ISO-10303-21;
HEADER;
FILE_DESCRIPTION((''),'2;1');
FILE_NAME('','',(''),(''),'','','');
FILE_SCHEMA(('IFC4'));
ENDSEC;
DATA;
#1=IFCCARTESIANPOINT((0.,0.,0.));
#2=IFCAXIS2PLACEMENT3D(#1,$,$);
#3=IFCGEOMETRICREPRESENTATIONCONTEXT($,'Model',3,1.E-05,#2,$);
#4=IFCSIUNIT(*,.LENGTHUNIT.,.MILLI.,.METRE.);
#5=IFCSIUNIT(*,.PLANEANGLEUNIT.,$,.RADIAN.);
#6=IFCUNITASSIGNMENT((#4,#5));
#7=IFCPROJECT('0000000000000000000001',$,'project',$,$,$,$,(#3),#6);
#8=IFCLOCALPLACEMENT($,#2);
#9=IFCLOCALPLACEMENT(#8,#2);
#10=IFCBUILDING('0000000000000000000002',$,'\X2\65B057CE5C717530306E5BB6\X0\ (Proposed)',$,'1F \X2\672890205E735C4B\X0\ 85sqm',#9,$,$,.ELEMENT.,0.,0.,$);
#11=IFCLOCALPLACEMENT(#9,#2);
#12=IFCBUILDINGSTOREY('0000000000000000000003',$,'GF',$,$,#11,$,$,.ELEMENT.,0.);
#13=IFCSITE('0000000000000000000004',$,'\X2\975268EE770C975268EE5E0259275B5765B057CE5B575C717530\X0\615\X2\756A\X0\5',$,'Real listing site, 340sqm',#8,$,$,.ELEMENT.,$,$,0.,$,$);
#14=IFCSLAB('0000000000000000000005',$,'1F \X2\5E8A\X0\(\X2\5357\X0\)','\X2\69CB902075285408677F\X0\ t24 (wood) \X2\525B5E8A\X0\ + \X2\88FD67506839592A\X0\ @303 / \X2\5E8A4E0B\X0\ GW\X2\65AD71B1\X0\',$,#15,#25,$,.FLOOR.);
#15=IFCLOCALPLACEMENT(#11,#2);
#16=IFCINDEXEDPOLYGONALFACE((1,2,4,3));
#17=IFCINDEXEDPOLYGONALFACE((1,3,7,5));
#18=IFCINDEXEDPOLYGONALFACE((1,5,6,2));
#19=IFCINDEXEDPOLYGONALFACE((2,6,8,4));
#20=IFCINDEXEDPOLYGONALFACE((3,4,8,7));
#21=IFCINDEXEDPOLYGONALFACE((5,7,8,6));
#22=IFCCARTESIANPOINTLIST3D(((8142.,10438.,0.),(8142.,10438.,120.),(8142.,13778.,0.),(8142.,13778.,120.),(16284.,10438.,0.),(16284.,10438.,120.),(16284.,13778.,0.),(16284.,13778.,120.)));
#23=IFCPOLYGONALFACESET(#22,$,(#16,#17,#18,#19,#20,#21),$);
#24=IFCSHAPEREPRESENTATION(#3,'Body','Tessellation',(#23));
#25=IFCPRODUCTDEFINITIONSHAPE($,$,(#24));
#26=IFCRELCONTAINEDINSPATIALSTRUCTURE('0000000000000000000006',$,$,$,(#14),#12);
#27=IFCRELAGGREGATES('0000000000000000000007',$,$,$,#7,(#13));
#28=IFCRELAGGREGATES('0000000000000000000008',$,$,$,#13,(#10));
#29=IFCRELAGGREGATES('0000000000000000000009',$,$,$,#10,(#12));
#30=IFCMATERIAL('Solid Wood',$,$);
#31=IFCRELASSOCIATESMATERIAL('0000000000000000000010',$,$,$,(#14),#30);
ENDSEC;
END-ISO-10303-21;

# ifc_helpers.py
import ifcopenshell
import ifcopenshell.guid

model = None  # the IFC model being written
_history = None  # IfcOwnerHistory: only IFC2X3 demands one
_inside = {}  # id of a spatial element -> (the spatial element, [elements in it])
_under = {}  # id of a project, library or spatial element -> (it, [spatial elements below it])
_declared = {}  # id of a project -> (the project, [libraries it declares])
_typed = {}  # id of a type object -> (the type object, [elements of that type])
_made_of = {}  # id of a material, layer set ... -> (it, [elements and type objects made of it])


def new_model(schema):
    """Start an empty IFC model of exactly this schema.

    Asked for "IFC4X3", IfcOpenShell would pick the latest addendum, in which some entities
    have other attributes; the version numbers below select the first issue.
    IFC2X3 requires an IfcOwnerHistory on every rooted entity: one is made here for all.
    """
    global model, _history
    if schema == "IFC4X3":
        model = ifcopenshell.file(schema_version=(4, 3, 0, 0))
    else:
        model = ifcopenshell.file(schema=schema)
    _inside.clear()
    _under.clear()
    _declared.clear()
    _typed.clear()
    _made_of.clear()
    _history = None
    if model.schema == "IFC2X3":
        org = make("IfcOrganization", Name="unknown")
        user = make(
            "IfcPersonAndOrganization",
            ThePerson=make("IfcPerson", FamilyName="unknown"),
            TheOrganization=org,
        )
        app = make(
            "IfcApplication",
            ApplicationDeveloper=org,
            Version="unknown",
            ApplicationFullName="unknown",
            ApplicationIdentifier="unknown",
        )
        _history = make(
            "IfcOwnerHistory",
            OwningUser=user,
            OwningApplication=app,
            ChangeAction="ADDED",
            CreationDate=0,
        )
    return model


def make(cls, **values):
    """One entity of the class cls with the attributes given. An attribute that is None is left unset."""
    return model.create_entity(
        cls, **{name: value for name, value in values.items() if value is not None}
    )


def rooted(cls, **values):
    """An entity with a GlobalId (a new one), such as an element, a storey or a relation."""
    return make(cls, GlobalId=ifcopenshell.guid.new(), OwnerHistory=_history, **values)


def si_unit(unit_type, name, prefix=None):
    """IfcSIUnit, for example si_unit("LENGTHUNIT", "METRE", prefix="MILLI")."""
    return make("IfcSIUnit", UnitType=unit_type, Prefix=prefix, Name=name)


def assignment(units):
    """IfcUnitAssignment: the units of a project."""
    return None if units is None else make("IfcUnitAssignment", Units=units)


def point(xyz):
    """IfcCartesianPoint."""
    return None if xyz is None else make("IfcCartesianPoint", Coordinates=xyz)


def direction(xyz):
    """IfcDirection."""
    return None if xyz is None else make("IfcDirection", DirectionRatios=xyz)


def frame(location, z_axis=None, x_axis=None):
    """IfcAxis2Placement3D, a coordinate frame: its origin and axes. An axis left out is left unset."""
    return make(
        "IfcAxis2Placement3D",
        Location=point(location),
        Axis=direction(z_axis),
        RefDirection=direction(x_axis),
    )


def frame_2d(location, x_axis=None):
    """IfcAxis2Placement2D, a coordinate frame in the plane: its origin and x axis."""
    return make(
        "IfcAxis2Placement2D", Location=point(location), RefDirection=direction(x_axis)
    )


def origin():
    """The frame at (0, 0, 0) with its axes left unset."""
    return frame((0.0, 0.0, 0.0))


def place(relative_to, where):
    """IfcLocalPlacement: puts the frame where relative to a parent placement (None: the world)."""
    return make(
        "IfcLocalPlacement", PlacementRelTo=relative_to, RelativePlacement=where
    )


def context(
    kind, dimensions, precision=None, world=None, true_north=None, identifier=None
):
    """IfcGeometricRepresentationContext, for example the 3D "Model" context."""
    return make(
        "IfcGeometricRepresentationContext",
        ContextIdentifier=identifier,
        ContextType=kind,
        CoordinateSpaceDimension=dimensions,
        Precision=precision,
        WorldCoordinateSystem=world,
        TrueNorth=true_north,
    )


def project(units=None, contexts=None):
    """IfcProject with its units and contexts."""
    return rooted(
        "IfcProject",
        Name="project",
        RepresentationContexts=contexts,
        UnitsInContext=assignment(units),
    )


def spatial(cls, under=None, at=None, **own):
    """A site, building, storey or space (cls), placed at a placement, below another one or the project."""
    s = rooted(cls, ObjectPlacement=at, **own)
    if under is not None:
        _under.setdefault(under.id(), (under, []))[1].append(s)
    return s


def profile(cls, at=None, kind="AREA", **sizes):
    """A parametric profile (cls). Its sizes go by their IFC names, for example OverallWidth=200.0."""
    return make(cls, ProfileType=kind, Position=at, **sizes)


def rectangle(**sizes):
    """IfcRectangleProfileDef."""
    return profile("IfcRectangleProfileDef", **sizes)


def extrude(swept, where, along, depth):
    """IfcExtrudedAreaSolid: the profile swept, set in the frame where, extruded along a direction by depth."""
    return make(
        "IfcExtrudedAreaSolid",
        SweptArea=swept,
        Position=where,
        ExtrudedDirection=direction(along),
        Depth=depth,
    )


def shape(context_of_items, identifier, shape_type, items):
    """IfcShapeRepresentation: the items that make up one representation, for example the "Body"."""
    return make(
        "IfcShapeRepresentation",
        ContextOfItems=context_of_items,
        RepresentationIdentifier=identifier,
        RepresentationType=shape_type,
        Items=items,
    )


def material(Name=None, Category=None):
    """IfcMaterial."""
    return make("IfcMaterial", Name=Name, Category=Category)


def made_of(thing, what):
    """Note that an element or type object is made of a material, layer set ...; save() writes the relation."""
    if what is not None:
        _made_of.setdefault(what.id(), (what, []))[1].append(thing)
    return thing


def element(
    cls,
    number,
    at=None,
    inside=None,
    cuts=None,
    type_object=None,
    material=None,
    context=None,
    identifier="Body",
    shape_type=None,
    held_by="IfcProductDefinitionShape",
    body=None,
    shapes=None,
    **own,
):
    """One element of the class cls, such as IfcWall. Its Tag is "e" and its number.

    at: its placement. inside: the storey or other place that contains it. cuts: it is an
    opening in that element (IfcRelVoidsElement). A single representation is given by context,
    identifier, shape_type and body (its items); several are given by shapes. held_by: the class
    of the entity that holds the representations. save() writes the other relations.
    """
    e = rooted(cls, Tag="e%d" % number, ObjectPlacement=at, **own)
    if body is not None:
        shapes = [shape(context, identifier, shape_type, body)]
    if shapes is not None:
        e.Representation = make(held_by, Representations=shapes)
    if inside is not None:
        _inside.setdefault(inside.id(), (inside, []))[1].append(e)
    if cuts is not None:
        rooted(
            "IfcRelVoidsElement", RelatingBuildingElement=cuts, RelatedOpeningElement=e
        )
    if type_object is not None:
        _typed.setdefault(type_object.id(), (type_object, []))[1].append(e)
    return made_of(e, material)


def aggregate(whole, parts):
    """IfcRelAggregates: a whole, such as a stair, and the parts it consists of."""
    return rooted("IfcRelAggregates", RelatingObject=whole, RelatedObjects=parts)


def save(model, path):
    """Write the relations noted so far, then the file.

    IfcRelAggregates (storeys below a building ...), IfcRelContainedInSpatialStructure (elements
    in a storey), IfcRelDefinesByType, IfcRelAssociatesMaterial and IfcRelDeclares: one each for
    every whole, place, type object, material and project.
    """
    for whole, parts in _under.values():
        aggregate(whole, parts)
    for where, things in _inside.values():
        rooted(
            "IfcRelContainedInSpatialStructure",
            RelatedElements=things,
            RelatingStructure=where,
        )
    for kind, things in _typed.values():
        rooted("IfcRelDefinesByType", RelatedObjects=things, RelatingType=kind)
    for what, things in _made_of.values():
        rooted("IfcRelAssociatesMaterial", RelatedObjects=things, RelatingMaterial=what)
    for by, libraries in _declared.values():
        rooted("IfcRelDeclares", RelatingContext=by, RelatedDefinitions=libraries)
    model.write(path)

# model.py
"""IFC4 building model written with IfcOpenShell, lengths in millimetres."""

from ifc_helpers import new_model, si_unit, frame, frame_2d, origin, place, context, project, spatial, rectangle, extrude, material, element, save


model = new_model("IFC4")

# Units and contexts
model_context = context("Model", 3, precision=1e-05, world=origin())
ifc_project = project(units=[si_unit("LENGTHUNIT", "METRE", prefix="MILLI"), si_unit("PLANEANGLEUNIT", "RADIAN")], contexts=[model_context])

# Site, building, storey
site_placement = place(None, origin())
site = spatial("IfcSite", under=ifc_project, at=site_placement, Name="青森県青森市大字新城字山田615番5", ObjectType="Real listing site, 340sqm", CompositionType="ELEMENT", RefElevation=0.0)
building_placement = place(site_placement, origin())
building = spatial("IfcBuilding", under=site, at=building_placement, Name="新城山田の家 (Proposed)", ObjectType="1F 木造平屋 85sqm", CompositionType="ELEMENT", ElevationOfRefHeight=0.0, ElevationOfTerrain=0.0)
storey_placement = place(building_placement, origin())
storey = spatial("IfcBuildingStorey", under=building, at=storey_placement, Name="GF", CompositionType="ELEMENT", Elevation=0.0)

# Shared definitions
ifc_material_1 = material(Name="Solid Wood")

# Slab
slab_1_placement = place(storey_placement, frame((4071.0, 5219.0, 0.0)))
element("IfcSlab", 1, at=slab_1_placement, inside=storey, material=ifc_material_1, Name="1F 床(南)", Description="構造用合板 t24 (wood) 剛床 + 製材根太 @303 / 床下 GW断熱", PredefinedType="FLOOR", context=model_context, shape_type="SweptSolid", body=[
    extrude(rectangle(XDim=8142.0, YDim=3340.0, at=frame_2d((4071.0, 1670.0))), frame((4071.0, 5219.0, 0.0)), (0.0, 0.0, 1.0), 120.0),
])

save(model, "model.ifc")
